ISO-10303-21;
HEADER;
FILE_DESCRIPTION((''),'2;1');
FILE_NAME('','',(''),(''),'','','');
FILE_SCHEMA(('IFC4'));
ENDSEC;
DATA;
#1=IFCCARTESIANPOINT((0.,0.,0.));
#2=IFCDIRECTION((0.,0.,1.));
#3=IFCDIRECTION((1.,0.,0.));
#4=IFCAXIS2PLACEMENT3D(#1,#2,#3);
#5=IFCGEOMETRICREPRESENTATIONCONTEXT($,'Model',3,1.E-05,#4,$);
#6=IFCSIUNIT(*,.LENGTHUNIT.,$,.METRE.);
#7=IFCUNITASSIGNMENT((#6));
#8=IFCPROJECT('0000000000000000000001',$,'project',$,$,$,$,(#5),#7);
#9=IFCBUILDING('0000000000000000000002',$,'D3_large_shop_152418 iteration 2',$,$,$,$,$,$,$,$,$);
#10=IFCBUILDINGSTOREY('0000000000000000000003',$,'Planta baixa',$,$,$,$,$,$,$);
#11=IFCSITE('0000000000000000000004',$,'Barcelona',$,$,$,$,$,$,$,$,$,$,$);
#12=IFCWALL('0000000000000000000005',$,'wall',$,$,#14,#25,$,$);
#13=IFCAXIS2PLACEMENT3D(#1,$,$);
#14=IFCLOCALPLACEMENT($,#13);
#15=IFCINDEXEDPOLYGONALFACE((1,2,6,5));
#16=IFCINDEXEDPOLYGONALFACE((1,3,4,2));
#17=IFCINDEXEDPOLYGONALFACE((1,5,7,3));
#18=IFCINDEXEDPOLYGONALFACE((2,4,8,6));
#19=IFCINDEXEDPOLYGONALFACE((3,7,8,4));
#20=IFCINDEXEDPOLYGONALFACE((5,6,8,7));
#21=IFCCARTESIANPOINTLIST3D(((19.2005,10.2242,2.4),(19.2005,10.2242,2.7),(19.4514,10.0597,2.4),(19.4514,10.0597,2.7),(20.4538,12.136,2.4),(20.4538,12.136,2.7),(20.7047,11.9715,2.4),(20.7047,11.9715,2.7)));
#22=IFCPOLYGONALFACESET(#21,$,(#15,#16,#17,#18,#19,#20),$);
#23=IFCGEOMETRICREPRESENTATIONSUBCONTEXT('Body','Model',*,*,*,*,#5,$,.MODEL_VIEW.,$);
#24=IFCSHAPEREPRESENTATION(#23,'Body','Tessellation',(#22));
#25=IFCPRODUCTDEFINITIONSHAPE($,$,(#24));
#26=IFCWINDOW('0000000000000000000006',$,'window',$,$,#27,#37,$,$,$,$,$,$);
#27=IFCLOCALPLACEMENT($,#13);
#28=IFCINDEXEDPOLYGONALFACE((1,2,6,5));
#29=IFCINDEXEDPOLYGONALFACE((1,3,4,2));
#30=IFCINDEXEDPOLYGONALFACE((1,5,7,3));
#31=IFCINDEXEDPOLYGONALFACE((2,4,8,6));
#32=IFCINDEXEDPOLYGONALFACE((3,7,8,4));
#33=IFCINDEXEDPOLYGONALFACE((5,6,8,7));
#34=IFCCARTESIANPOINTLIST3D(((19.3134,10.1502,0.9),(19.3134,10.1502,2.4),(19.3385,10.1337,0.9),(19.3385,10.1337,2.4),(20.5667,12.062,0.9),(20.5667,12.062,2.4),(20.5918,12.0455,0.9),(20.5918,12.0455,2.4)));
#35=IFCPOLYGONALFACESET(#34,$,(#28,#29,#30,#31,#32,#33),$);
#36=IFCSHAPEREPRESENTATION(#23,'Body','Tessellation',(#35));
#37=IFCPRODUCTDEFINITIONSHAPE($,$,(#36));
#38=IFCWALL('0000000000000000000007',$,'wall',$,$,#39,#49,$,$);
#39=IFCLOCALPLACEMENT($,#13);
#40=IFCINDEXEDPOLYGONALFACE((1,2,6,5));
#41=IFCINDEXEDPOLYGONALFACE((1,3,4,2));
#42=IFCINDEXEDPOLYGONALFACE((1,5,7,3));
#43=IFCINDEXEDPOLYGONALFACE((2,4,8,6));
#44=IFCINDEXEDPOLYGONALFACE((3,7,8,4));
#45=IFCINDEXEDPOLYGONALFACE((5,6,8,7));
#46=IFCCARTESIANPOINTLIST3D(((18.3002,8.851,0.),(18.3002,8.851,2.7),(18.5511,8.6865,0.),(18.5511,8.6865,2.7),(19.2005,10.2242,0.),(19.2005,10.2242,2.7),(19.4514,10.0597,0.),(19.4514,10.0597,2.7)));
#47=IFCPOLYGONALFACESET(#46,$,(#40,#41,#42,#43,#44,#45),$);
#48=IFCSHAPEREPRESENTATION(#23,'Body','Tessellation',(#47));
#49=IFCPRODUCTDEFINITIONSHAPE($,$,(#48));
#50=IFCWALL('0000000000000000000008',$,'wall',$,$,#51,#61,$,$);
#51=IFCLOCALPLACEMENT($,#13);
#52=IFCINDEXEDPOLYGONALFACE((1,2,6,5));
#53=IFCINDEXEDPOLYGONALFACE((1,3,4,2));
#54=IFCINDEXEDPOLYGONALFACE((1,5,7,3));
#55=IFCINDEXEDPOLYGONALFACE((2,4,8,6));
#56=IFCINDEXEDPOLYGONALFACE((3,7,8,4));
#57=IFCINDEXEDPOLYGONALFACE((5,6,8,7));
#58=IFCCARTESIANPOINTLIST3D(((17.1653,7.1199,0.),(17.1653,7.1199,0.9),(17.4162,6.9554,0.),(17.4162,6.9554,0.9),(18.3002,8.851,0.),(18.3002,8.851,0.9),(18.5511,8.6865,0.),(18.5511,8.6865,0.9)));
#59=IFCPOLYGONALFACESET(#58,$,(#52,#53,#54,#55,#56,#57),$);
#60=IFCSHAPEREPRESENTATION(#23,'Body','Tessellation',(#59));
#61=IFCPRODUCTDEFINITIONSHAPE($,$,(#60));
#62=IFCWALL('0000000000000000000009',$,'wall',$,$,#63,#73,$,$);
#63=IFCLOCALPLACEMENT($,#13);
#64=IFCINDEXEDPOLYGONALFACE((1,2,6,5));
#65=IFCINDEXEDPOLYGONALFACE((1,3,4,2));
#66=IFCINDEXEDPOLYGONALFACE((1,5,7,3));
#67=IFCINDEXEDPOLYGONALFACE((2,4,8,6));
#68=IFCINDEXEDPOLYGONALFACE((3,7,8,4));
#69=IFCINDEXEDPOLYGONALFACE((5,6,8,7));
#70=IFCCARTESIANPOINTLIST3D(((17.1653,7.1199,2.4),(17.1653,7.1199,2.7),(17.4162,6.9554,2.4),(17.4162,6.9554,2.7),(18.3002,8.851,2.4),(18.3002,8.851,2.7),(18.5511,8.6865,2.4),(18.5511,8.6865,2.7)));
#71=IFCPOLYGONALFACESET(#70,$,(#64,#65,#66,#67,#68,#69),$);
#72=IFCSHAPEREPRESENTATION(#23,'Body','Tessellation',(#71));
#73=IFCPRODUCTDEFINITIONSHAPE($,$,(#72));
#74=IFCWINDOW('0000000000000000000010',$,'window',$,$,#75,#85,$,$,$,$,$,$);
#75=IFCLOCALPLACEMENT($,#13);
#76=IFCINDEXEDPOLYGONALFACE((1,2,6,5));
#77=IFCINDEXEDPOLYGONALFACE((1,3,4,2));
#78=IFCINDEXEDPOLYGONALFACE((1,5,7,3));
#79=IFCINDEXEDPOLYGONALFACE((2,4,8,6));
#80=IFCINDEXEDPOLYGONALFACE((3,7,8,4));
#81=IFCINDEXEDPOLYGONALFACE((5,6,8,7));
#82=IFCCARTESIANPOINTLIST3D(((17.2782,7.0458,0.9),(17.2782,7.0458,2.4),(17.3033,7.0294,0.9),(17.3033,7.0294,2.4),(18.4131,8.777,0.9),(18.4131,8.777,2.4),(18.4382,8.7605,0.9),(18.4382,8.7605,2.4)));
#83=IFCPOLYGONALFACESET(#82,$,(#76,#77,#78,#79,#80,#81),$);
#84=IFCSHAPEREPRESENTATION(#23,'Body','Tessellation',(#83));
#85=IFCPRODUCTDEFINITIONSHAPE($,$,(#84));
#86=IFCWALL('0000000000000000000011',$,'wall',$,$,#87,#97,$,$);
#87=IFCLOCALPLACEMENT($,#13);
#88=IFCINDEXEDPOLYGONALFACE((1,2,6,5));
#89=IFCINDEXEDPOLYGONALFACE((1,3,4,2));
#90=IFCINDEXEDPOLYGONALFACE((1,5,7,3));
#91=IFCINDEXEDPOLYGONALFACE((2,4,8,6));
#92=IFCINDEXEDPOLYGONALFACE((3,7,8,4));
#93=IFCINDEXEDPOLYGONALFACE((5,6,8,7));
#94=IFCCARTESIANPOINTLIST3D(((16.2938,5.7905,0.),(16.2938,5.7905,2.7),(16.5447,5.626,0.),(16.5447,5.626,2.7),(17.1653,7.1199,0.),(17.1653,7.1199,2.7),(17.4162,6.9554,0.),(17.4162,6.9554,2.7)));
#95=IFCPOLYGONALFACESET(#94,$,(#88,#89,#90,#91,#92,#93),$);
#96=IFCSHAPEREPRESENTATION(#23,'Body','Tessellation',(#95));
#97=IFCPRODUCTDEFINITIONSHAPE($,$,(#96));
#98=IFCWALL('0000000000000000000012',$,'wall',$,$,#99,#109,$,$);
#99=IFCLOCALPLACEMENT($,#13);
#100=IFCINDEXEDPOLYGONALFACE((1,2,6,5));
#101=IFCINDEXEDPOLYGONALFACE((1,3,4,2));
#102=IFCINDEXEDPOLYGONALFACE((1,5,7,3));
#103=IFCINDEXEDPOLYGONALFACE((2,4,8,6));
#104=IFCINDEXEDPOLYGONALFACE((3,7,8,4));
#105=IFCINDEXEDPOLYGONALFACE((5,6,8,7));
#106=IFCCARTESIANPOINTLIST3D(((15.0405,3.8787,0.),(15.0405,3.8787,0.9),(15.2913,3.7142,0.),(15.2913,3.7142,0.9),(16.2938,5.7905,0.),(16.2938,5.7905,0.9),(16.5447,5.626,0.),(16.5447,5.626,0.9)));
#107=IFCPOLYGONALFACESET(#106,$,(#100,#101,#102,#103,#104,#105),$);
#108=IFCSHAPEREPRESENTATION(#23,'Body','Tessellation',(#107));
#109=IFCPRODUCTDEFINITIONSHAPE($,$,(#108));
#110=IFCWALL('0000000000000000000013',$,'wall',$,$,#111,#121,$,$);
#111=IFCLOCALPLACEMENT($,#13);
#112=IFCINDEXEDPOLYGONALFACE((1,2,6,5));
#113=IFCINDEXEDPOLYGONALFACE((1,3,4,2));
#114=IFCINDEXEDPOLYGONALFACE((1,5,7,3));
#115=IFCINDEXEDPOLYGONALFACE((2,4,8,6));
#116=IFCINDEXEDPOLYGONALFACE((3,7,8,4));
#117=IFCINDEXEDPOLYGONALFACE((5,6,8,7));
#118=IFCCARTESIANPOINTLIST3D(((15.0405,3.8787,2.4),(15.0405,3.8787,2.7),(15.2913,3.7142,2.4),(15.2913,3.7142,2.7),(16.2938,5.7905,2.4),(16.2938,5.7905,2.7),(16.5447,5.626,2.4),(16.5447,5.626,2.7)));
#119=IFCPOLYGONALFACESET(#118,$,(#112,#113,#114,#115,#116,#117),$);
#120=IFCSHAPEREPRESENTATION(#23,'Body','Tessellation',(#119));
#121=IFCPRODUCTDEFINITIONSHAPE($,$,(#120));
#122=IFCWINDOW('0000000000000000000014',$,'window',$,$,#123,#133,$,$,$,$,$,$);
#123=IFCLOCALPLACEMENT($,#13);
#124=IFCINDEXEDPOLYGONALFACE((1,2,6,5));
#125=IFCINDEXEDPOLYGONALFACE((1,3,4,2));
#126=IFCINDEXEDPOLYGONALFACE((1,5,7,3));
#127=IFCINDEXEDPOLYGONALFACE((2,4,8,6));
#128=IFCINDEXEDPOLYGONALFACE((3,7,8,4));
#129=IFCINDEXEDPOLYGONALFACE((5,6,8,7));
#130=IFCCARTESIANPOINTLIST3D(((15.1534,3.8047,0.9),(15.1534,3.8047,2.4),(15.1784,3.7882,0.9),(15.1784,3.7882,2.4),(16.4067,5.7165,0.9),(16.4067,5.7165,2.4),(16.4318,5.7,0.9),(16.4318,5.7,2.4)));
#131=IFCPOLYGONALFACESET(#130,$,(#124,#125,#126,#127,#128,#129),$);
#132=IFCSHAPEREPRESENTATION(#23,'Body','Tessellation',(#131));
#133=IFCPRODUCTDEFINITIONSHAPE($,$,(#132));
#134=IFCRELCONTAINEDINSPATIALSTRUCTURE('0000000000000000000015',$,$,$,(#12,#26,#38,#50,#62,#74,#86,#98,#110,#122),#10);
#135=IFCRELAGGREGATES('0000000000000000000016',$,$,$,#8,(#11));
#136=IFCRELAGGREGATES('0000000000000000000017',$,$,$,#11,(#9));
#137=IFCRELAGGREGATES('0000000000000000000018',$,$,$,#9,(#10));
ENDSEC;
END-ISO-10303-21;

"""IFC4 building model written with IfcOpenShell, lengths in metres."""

from ifc_helpers import new_model, si_unit, frame, origin, origin_with_axes, place, context, subcontext, project, spatial, polyline, outline, extrude, element, save


model = new_model("IFC4")

# Units and contexts
model_context = context("Model", 3, precision=1e-05, world=origin_with_axes())
body_context = subcontext(model_context, "Body", "Model", "MODEL_VIEW")
ifc_project = project(units=[si_unit("LENGTHUNIT", "METRE")], contexts=[model_context])

# Site, building, storey
site = spatial("IfcSite", under=ifc_project, Name="Barcelona")
building = spatial("IfcBuilding", under=site, Name="D3_large_shop_152418 iteration 2")
storey = spatial("IfcBuildingStorey", under=building, Name="Planta baixa")

# Wall
wall_1_placement = place(None, origin_with_axes())
element("IfcWall", 1, at=wall_1_placement, inside=storey, Name="wall", context=body_context, shape_type="SweptSolid", body=[
    extrude(outline(polyline([(20.7047, 11.9715), (19.4514, 10.0597), (19.2005, 10.2242), (20.4538, 12.136), (20.7047, 11.9715)])), frame((0.0, 0.0, 2.4)), (0.0, 0.0, 1.0), 0.3),
])

# Window
window_1_placement = place(None, origin_with_axes())
element("IfcWindow", 2, at=window_1_placement, inside=storey, Name="window", context=body_context, shape_type="SweptSolid", body=[
    extrude(outline(polyline([(20.5918, 12.0455), (19.3385, 10.1337), (19.3134, 10.1502), (20.5667, 12.062), (20.5918, 12.0455)])), frame((0.0, 0.0, 0.9)), (0.0, 0.0, 1.0), 1.5),
])

# Walls
wall_2_placement = place(None, origin_with_axes())
element("IfcWall", 3, at=wall_2_placement, inside=storey, Name="wall", context=body_context, shape_type="SweptSolid", body=[
    extrude(outline(polyline([(19.4514, 10.0597), (18.5511, 8.6865), (18.3002, 8.851), (19.2005, 10.2242), (19.4514, 10.0597)])), origin(), (0.0, 0.0, 1.0), 2.7),
])
wall_3_placement = place(None, origin_with_axes())
element("IfcWall", 4, at=wall_3_placement, inside=storey, Name="wall", context=body_context, shape_type="SweptSolid", body=[
    extrude(outline(polyline([(18.5511, 8.6865), (17.4162, 6.9554), (17.1653, 7.1199), (18.3002, 8.851), (18.5511, 8.6865)])), origin(), (0.0, 0.0, 1.0), 0.9),
])
wall_4_placement = place(None, origin_with_axes())
element("IfcWall", 5, at=wall_4_placement, inside=storey, Name="wall", context=body_context, shape_type="SweptSolid", body=[
    extrude(outline(polyline([(18.5511, 8.6865), (17.4162, 6.9554), (17.1653, 7.1199), (18.3002, 8.851), (18.5511, 8.6865)])), frame((0.0, 0.0, 2.4)), (0.0, 0.0, 1.0), 0.3),
])

# Window
window_2_placement = place(None, origin_with_axes())
element("IfcWindow", 6, at=window_2_placement, inside=storey, Name="window", context=body_context, shape_type="SweptSolid", body=[
    extrude(outline(polyline([(18.4382, 8.7605), (17.3033, 7.0294), (17.2782, 7.0458), (18.4131, 8.777), (18.4382, 8.7605)])), frame((0.0, 0.0, 0.9)), (0.0, 0.0, 1.0), 1.5),
])

# Walls
wall_5_placement = place(None, origin_with_axes())
element("IfcWall", 7, at=wall_5_placement, inside=storey, Name="wall", context=body_context, shape_type="SweptSolid", body=[
    extrude(outline(polyline([(17.4162, 6.9554), (16.5447, 5.626), (16.2938, 5.7905), (17.1653, 7.1199), (17.4162, 6.9554)])), origin(), (0.0, 0.0, 1.0), 2.7),
])
wall_6_placement = place(None, origin_with_axes())
element("IfcWall", 8, at=wall_6_placement, inside=storey, Name="wall", context=body_context, shape_type="SweptSolid", body=[
    extrude(outline(polyline([(16.5447, 5.626), (15.2913, 3.7142), (15.0405, 3.8787), (16.2938, 5.7905), (16.5447, 5.626)])), origin(), (0.0, 0.0, 1.0), 0.9),
])
wall_7_placement = place(None, origin_with_axes())
element("IfcWall", 9, at=wall_7_placement, inside=storey, Name="wall", context=body_context, shape_type="SweptSolid", body=[
    extrude(outline(polyline([(16.5447, 5.626), (15.2913, 3.7142), (15.0405, 3.8787), (16.2938, 5.7905), (16.5447, 5.626)])), frame((0.0, 0.0, 2.4)), (0.0, 0.0, 1.0), 0.3),
])

# Window
window_3_placement = place(None, origin_with_axes())
element("IfcWindow", 10, at=window_3_placement, inside=storey, Name="window", context=body_context, shape_type="SweptSolid", body=[
    extrude(outline(polyline([(16.4318, 5.7), (15.1784, 3.7882), (15.1534, 3.8047), (16.4067, 5.7165), (16.4318, 5.7)])), frame((0.0, 0.0, 0.9)), (0.0, 0.0, 1.0), 1.5),
])

save(model, "model.ifc")
